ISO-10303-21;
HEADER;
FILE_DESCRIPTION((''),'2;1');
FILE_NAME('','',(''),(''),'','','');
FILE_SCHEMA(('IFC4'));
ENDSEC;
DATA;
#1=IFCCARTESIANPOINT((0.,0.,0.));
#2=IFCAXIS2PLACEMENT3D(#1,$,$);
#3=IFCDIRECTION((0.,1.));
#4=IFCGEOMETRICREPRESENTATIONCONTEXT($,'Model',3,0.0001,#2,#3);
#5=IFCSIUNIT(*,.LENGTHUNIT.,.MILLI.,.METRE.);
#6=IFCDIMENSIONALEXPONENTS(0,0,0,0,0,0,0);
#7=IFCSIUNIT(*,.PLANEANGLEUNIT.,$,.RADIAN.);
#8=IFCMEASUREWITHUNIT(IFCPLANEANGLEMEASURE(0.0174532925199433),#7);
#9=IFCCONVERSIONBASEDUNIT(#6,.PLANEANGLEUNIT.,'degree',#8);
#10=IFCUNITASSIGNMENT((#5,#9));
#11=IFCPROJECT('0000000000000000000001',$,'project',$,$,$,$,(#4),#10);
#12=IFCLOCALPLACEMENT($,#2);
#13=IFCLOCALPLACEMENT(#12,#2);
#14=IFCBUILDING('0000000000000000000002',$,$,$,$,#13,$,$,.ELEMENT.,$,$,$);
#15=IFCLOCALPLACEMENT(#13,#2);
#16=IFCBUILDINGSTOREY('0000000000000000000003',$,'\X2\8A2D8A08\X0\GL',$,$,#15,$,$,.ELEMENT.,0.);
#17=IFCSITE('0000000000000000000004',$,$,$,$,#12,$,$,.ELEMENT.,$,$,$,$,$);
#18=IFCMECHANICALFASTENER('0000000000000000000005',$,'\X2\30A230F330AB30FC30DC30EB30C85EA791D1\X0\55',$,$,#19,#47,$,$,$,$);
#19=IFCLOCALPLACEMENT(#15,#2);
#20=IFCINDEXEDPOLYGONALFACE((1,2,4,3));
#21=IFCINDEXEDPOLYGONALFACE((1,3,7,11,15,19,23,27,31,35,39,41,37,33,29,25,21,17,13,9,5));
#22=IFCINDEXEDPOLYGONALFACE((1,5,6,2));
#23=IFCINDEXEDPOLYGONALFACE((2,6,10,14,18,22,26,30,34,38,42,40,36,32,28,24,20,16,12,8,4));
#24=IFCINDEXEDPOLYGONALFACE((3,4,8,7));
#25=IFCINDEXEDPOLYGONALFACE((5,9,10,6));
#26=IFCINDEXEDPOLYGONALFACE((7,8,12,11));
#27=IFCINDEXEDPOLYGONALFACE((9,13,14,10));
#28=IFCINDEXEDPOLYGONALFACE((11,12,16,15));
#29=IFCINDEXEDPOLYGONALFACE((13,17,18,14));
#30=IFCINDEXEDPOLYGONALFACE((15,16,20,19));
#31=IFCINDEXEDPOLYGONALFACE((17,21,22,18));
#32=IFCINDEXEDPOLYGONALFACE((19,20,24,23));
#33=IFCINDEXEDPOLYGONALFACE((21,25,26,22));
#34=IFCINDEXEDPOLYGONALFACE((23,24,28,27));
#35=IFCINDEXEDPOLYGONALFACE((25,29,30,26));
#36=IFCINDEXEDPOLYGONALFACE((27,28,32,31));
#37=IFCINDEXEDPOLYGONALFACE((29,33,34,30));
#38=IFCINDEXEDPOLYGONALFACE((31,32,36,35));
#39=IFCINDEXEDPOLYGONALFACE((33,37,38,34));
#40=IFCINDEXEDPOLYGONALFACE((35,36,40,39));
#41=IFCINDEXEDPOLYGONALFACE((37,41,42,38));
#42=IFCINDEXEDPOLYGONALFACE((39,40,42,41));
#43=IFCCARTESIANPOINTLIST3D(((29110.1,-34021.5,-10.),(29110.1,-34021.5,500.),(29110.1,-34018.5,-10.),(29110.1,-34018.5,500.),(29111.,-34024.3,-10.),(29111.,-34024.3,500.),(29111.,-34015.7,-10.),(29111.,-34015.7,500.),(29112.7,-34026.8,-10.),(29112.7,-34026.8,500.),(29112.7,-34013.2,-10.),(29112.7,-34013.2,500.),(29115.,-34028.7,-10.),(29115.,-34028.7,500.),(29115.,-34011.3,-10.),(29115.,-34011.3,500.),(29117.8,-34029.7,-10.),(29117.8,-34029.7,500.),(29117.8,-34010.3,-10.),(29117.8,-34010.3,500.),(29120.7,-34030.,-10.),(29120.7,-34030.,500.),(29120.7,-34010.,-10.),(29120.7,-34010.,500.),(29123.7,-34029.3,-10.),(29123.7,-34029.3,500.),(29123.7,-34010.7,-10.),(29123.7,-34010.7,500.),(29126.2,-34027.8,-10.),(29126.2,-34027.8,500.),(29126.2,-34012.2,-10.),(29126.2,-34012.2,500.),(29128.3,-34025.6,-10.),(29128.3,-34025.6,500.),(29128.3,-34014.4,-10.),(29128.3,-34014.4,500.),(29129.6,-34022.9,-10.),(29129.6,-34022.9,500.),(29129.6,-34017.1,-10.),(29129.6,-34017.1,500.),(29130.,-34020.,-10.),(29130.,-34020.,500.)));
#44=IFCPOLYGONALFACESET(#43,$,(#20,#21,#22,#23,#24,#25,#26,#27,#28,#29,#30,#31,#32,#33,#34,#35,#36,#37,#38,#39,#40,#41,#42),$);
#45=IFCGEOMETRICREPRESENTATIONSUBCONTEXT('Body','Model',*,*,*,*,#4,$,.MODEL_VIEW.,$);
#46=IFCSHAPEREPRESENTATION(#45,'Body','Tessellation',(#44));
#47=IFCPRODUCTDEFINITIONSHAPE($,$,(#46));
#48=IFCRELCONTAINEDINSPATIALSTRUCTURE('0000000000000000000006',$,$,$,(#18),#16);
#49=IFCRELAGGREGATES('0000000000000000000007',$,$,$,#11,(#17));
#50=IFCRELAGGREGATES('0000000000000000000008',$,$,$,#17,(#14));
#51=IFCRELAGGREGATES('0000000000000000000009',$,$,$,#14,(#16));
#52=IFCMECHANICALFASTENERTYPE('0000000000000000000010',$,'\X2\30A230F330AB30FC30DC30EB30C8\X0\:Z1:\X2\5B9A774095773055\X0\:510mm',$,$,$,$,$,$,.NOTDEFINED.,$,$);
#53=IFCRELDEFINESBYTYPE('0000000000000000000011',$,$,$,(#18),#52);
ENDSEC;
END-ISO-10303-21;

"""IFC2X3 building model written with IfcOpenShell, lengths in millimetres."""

from ifc_helpers import new_model, entity, si_unit, converted_unit, direction, frame, origin, origin_with_axes, origin_2d, place, context, subcontext, project, spatial, circle, extrude, type_object, element, save


model = new_model("IFC2X3")

# Units and contexts
model_context = context("Model", 3, precision=0.0001, world=origin(), true_north=direction((0.0, 1.0)))
body_context = subcontext(model_context, "Body", "Model", "MODEL_VIEW")
ifc_project = project(units=[si_unit("LENGTHUNIT", "METRE", prefix="MILLI"), converted_unit("PLANEANGLEUNIT", "degree", entity("IfcPlaneAngleMeasure", 0.0174532925199433), si_unit("PLANEANGLEUNIT", "RADIAN"), dimensions=[0, 0, 0, 0, 0, 0, 0])], contexts=[model_context])

# Site, building, storey
site_placement = place(None, origin())
site = spatial("IfcSite", under=ifc_project, at=site_placement, CompositionType="ELEMENT")
building_placement = place(site_placement, origin())
building = spatial("IfcBuilding", under=site, at=building_placement, CompositionType="ELEMENT")
storey_placement = place(building_placement, origin())
storey = spatial("IfcBuildingStorey", under=building, at=storey_placement, Name="設計GL", CompositionType="ELEMENT", Elevation=0.0)

# Mechanical fastener
mechanical_fastener_type_1 = type_object("IfcMechanicalFastenerType", Name="アンカーボルト:Z1:定着長さ:510mm")
mechanical_fastener_1_placement = place(storey_placement, frame((29120.0, -34020.0, -10.0)))
element("IfcMechanicalFastener", 1, at=mechanical_fastener_1_placement, inside=storey, type_object=mechanical_fastener_type_1, Name="アンカーボルト座金55", context=body_context, shape_type="SweptSolid", body=[
    extrude(circle(Radius=10.0, at=origin_2d()), origin_with_axes(), (0.0, 0.0, 1.0), 510.0),
])

save(model, "model.ifc")
